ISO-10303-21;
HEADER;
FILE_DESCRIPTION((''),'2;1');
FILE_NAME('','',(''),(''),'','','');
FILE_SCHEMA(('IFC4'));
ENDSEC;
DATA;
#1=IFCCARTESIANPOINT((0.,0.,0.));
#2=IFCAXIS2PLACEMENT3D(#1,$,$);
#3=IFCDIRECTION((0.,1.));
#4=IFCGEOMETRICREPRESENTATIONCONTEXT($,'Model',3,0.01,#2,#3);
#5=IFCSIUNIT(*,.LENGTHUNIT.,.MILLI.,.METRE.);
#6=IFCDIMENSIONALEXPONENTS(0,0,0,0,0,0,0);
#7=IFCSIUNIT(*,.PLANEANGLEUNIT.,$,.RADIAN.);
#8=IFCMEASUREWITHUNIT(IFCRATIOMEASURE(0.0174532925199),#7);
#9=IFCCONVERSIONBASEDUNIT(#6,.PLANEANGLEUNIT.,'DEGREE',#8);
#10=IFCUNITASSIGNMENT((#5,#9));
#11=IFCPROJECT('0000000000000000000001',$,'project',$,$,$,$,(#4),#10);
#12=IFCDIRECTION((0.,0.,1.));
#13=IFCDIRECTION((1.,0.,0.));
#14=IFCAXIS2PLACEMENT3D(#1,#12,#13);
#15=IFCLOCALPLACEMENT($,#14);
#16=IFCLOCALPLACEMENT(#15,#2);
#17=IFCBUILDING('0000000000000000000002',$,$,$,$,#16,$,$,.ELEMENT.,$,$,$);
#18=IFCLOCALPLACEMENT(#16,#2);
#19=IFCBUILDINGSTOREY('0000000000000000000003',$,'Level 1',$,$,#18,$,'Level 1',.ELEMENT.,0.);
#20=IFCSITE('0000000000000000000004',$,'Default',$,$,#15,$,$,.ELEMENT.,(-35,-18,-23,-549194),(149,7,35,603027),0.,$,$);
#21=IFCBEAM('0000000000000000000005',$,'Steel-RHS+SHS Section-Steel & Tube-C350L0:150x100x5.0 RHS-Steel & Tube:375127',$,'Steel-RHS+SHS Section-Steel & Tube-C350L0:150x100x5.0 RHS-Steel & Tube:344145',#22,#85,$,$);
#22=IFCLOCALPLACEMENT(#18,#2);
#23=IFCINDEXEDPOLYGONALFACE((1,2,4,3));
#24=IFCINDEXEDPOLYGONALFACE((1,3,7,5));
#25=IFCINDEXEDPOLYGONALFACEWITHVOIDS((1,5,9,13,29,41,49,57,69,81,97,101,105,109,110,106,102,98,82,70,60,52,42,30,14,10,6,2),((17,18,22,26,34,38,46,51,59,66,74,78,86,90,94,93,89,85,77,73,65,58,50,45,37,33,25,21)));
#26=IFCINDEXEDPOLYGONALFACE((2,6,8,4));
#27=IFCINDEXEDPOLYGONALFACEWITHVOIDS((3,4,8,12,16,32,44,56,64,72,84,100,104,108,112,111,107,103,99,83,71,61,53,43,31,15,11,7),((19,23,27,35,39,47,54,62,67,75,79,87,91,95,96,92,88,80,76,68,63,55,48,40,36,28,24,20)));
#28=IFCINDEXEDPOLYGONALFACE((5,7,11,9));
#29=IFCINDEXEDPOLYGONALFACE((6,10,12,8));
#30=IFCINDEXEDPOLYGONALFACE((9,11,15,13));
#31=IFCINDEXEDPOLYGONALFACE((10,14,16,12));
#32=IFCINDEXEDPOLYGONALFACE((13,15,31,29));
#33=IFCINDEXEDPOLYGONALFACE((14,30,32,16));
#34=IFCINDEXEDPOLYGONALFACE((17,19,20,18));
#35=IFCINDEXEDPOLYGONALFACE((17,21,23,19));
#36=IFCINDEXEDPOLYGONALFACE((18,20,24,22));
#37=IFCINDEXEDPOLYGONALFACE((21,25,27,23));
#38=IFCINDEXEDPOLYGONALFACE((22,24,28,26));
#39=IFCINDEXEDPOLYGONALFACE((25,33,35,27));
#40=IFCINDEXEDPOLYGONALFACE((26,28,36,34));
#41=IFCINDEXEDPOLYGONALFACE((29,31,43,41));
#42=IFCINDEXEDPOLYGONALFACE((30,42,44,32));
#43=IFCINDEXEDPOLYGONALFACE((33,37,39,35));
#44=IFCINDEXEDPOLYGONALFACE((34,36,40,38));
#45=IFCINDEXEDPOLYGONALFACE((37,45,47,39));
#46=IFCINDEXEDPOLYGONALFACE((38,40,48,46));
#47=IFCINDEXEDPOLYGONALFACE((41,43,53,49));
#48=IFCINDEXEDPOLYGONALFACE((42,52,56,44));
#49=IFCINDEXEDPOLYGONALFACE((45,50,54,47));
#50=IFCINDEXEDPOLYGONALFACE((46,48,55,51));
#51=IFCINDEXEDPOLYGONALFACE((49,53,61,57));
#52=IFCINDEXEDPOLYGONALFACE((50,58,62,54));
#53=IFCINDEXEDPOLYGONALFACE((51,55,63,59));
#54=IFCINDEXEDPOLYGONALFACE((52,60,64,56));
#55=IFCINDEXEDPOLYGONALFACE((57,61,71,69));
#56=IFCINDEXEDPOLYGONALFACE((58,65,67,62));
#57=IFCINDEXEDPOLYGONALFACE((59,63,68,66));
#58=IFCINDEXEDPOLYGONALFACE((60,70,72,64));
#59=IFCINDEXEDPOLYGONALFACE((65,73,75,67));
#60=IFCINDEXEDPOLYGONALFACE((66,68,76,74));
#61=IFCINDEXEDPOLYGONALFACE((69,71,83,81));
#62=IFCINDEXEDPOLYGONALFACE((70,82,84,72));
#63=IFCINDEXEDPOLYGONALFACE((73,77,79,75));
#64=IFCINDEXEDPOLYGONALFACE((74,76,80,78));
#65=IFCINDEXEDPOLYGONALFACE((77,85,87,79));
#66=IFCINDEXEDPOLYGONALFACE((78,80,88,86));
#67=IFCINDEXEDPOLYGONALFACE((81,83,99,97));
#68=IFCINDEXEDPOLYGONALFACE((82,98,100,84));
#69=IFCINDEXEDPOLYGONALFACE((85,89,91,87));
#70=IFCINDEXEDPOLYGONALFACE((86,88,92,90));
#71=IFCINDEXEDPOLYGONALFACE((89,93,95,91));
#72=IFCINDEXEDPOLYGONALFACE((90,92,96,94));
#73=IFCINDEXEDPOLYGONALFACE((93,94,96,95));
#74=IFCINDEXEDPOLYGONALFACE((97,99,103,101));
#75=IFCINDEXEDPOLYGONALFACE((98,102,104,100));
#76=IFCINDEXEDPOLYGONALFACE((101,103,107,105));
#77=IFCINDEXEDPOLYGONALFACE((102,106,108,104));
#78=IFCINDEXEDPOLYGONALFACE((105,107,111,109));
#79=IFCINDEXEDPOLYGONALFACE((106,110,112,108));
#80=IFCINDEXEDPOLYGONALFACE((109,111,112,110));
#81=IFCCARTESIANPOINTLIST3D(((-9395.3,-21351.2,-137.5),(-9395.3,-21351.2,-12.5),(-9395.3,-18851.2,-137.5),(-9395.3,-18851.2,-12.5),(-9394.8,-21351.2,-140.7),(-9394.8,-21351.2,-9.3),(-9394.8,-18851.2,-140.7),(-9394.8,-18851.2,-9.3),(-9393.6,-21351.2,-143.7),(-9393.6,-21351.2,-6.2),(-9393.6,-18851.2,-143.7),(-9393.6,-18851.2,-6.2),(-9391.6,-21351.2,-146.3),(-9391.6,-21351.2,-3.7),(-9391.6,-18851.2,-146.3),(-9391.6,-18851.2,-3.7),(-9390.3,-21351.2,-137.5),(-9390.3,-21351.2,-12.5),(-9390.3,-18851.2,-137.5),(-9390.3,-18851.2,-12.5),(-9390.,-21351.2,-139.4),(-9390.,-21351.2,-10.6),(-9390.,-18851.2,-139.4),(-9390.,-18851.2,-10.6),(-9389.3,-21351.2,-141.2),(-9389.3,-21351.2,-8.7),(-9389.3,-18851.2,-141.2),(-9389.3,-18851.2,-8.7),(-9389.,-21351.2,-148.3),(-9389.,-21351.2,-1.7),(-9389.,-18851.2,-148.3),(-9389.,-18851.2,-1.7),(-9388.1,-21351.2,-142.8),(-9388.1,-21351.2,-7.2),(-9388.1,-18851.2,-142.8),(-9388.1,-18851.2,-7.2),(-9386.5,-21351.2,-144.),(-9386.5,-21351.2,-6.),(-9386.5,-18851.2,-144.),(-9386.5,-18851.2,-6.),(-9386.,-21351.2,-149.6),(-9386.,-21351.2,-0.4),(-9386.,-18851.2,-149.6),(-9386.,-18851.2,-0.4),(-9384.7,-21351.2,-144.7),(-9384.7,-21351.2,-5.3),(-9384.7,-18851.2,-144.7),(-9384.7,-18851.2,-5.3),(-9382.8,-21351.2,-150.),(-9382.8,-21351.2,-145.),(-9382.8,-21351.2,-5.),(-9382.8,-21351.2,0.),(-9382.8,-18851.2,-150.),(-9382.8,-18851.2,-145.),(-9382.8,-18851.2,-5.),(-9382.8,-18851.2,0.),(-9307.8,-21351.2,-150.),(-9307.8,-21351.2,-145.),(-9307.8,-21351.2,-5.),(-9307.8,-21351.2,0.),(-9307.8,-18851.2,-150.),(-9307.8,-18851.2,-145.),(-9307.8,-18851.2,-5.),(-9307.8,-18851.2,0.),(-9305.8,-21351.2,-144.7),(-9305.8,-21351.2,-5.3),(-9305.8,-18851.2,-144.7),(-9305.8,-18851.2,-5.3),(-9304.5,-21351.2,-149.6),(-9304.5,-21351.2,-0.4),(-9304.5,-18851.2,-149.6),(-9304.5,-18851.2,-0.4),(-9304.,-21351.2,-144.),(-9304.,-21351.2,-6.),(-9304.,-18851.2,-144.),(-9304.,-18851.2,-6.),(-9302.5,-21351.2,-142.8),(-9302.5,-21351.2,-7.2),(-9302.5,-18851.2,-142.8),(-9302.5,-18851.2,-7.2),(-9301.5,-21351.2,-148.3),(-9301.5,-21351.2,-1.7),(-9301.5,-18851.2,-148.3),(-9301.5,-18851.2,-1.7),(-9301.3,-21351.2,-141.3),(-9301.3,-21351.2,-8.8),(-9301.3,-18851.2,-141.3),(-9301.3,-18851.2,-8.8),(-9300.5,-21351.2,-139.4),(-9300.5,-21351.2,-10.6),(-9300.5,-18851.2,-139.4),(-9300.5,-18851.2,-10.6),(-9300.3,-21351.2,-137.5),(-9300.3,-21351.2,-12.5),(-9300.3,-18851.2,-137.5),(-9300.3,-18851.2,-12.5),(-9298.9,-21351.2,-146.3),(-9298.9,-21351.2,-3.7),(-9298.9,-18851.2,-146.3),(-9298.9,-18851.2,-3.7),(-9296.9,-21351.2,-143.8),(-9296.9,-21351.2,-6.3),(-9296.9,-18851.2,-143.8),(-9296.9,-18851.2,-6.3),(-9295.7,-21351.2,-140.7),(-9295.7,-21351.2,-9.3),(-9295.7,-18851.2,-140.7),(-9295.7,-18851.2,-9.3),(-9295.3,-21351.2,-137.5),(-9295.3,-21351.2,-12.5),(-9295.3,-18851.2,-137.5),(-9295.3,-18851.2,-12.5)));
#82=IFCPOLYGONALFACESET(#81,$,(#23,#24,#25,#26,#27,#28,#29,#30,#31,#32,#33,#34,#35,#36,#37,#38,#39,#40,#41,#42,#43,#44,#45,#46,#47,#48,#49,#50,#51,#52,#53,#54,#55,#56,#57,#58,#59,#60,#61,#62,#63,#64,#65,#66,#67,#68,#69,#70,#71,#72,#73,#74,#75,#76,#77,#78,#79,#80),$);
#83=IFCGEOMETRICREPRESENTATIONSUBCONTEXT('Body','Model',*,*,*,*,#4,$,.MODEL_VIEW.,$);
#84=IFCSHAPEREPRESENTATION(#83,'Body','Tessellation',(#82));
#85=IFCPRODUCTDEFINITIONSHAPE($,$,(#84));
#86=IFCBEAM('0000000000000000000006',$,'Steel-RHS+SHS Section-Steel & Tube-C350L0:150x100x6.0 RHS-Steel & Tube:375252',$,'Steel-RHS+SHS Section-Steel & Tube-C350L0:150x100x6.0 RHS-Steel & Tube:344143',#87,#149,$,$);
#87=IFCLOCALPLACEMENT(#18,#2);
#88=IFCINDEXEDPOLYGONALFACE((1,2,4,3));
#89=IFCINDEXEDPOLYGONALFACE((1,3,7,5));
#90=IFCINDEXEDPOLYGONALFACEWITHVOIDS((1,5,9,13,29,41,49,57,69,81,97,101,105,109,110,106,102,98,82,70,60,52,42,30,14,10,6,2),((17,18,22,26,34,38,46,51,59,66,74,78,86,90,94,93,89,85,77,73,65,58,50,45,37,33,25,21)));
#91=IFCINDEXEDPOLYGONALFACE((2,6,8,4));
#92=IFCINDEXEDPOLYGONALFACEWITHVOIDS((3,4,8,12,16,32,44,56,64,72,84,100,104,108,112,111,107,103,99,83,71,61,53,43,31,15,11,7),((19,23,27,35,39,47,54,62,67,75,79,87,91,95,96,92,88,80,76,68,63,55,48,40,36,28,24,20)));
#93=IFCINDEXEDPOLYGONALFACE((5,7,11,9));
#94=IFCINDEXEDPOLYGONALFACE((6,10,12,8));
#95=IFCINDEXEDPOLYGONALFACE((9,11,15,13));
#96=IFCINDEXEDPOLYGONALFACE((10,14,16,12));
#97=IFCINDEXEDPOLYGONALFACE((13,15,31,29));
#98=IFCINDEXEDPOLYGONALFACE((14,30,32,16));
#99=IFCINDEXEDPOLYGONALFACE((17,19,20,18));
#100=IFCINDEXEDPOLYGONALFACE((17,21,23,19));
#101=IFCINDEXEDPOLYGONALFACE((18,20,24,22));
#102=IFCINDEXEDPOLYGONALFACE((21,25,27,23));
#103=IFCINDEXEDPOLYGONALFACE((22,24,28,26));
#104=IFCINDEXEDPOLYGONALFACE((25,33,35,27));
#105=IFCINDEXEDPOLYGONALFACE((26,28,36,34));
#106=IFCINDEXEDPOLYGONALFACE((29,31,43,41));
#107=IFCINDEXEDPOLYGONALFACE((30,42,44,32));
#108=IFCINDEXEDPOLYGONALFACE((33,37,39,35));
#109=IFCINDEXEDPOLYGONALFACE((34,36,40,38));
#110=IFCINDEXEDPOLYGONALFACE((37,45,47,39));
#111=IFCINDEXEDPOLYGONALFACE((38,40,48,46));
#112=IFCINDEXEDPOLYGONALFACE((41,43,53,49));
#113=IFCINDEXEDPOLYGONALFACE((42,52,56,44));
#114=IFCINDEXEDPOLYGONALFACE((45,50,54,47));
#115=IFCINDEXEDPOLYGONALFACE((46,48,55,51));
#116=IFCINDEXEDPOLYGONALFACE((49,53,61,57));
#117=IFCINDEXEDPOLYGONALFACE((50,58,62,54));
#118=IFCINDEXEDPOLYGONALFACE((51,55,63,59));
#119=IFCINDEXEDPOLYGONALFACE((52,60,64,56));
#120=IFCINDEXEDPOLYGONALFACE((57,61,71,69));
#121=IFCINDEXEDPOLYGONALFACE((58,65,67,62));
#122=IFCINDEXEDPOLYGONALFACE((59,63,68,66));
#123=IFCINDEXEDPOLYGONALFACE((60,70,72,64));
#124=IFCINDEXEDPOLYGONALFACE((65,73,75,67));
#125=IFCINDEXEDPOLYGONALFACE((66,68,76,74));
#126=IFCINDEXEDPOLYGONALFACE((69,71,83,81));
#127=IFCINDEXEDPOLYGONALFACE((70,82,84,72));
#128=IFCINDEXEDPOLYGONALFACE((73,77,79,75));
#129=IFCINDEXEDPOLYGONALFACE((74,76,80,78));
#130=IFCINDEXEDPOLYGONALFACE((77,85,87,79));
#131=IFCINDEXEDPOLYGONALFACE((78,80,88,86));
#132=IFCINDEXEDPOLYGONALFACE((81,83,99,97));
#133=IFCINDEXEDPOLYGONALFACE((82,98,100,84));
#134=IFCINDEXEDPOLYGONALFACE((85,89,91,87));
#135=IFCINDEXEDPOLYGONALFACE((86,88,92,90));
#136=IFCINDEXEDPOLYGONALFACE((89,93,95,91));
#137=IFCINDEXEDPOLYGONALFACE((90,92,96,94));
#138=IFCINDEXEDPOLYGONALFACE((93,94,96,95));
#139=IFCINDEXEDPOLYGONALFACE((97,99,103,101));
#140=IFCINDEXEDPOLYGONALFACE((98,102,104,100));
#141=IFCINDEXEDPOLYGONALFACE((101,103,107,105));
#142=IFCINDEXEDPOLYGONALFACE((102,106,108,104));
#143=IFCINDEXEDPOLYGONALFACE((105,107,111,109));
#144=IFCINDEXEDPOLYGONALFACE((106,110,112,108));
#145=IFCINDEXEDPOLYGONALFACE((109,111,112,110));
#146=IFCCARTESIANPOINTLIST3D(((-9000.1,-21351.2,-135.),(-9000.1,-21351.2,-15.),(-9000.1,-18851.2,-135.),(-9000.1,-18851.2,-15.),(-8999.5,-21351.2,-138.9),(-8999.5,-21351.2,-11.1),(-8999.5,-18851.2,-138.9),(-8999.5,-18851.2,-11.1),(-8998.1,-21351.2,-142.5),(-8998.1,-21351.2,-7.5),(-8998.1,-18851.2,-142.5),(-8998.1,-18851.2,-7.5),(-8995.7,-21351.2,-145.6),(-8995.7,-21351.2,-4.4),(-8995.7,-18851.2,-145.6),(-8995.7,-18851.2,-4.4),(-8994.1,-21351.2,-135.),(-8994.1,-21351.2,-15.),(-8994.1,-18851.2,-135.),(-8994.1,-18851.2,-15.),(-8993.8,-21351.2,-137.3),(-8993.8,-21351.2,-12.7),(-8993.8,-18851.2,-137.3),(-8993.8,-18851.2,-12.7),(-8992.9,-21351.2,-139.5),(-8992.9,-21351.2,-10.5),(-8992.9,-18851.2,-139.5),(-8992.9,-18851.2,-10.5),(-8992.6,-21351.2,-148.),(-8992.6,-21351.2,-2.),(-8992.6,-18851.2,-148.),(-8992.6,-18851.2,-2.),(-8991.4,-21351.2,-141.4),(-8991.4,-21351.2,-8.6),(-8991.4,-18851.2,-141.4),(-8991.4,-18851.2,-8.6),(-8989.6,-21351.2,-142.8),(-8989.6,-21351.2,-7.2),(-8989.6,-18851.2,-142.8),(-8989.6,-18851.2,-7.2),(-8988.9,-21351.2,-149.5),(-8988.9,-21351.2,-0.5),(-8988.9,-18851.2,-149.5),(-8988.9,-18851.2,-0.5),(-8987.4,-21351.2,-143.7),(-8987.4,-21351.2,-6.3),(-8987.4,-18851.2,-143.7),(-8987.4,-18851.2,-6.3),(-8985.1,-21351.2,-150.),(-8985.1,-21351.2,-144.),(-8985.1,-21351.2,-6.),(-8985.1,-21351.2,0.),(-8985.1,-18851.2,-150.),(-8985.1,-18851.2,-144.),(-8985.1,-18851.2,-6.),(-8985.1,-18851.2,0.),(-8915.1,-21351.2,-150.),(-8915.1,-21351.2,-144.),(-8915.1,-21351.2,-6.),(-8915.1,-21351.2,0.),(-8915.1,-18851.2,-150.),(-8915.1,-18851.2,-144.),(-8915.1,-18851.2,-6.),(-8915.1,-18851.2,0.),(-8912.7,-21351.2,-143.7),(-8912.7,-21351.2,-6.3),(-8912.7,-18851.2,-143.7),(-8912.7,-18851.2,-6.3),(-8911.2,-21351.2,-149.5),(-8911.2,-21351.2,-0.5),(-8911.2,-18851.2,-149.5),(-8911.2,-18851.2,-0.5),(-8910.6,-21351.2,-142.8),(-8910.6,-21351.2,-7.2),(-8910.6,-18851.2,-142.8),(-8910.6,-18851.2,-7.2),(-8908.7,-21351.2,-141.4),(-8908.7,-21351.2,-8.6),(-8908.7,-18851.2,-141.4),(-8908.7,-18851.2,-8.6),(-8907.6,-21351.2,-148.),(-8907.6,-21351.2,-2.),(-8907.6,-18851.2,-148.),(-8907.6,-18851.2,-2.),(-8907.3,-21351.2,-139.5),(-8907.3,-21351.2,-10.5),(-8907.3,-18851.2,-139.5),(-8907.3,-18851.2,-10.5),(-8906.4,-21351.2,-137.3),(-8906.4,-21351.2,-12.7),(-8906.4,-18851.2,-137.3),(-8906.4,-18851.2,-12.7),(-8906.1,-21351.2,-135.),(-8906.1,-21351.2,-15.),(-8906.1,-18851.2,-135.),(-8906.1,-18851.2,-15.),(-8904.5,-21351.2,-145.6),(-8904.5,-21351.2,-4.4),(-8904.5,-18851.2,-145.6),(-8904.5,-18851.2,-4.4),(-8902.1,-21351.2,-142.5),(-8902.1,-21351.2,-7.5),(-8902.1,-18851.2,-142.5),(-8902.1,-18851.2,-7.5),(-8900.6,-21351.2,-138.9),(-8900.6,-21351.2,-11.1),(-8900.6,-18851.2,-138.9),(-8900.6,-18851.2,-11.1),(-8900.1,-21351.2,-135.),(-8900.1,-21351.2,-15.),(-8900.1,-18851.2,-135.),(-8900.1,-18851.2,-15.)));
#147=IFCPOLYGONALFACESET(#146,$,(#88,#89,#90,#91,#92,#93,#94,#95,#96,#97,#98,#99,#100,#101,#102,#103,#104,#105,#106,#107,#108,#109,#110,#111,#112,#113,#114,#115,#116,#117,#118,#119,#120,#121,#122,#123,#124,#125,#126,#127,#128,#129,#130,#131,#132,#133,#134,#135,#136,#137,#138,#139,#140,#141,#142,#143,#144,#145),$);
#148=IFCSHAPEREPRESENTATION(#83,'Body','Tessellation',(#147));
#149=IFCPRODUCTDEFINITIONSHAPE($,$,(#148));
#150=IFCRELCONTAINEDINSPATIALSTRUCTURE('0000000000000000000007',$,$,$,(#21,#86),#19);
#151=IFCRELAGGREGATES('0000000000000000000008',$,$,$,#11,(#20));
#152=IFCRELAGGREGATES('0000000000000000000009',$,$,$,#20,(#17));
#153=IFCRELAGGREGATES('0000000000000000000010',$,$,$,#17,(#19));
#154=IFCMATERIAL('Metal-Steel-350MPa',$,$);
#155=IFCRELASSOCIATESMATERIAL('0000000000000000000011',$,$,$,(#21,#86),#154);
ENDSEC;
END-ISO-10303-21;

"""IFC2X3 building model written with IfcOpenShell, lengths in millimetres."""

from ifc_helpers import new_model, entity, si_unit, converted_unit, direction, frame, frame_2d, origin, origin_with_axes, place, context, subcontext, project, spatial, polyline, circle_curve, parameter, trimmed, segment, composite_curve, outline, extrude, material, element, save


model = new_model("IFC2X3")

# Units and contexts
model_context = context("Model", 3, precision=0.01, world=origin(), true_north=direction((0.0, 1.0)))
body_context = subcontext(model_context, "Body", "Model", "MODEL_VIEW")
ifc_project = project(units=[si_unit("LENGTHUNIT", "METRE", prefix="MILLI"), converted_unit("PLANEANGLEUNIT", "DEGREE", entity("IfcRatioMeasure", 0.0174532925199), si_unit("PLANEANGLEUNIT", "RADIAN"), dimensions=[0, 0, 0, 0, 0, 0, 0])], contexts=[model_context])

# Site, building, storey
site_placement = place(None, origin_with_axes())
site = spatial("IfcSite", under=ifc_project, at=site_placement, Name="Default", CompositionType="ELEMENT", RefLatitude=(-35, -18, -23, -549194), RefLongitude=(149, 7, 35, 603027), RefElevation=0.0)
building_placement = place(site_placement, origin())
building = spatial("IfcBuilding", under=site, at=building_placement, CompositionType="ELEMENT")
storey_placement = place(building_placement, origin())
storey = spatial("IfcBuildingStorey", under=building, at=storey_placement, Name="Level 1", LongName="Level 1", CompositionType="ELEMENT", Elevation=0.0)

# Beams
ifc_material = material(Name="Metal-Steel-350MPa")
beam_1_placement = place(storey_placement, frame((-9345.3, -18851.2, 0.0), z_axis=(0.0, 0.0, 1.0), x_axis=(0.0, -1.0, 0.0)))
element("IfcBeam", 1, at=beam_1_placement, inside=storey, material=ifc_material, Name="Steel-RHS+SHS Section-Steel & Tube-C350L0:150x100x5.0 RHS-Steel & Tube:375127", ObjectType="Steel-RHS+SHS Section-Steel & Tube-C350L0:150x100x5.0 RHS-Steel & Tube:344145", context=body_context, shape_type="SweptSolid", body=[
    extrude(outline(composite_curve([segment(trimmed(circle_curve(frame_2d((-37.5, -62.5), x_axis=(1.0, 0.0)), 12.5), [parameter(180.0)], [parameter(270.0)], True, "PARAMETER"), True, "CONTINUOUS"), segment(polyline([(-37.5, -75.0), (37.5, -75.0)]), True, "CONTINUOUS"), segment(trimmed(circle_curve(frame_2d((37.5, -62.5), x_axis=(1.0, 0.0)), 12.5), [parameter(270.0)], [parameter(0.0)], True, "PARAMETER"), True, "CONTINUOUS"), segment(polyline([(50.0, -62.5), (50.0, 62.5)]), True, "CONTINUOUS"), segment(trimmed(circle_curve(frame_2d((37.5, 62.5), x_axis=(1.0, 0.0)), 12.5), [parameter(0.0)], [parameter(90.0)], True, "PARAMETER"), True, "CONTINUOUS"), segment(polyline([(37.5, 75.0), (-37.5, 75.0)]), True, "CONTINUOUS"), segment(trimmed(circle_curve(frame_2d((-37.5, 62.5), x_axis=(1.0, 0.0)), 12.5), [parameter(90.0)], [parameter(180.0)], True, "PARAMETER"), True, "CONTINUOUS"), segment(polyline([(-50.0, 62.5), (-50.0, -62.5)]), True, "CONTINUOUS")], self_intersect=False), holes=[composite_curve([segment(polyline([(37.5, -70.0), (-37.5, -70.0)]), True, "CONTINUOUS"), segment(trimmed(circle_curve(frame_2d((-37.5, -62.5), x_axis=(1.0, 0.0)), 7.5), [parameter(180.0)], [parameter(270.0)], True, "PARAMETER"), False, "CONTINUOUS"), segment(polyline([(-45.0, -62.5), (-45.0, 62.5)]), True, "CONTINUOUS"), segment(trimmed(circle_curve(frame_2d((-37.5, 62.5), x_axis=(1.0, 0.0)), 7.5), [parameter(90.0)], [parameter(180.0)], True, "PARAMETER"), False, "CONTINUOUS"), segment(polyline([(-37.5, 70.0), (37.5, 70.0)]), True, "CONTINUOUS"), segment(trimmed(circle_curve(frame_2d((37.5, 62.5), x_axis=(1.0, 0.0)), 7.5), [parameter(360.0)], [parameter(90.0)], True, "PARAMETER"), False, "CONTINUOUS"), segment(polyline([(45.0, 62.5), (45.0, -62.5)]), True, "CONTINUOUS"), segment(trimmed(circle_curve(frame_2d((37.5, -62.5), x_axis=(1.0, 0.0)), 7.5), [parameter(270.0)], [parameter(0.0)], True, "PARAMETER"), False, "CONTINUOUS")], self_intersect=False)]), frame((0.0, 0.0, -75.0), z_axis=(1.0, 0.0, 0.0), x_axis=(0.0, -1.0, 0.0)), (0.0, 0.0, 1.0), 2500.0),
])
beam_2_placement = place(storey_placement, frame((-8950.1, -18851.2, 0.0), z_axis=(0.0, 0.0, 1.0), x_axis=(0.0, -1.0, 0.0)))
element("IfcBeam", 2, at=beam_2_placement, inside=storey, material=ifc_material, Name="Steel-RHS+SHS Section-Steel & Tube-C350L0:150x100x6.0 RHS-Steel & Tube:375252", ObjectType="Steel-RHS+SHS Section-Steel & Tube-C350L0:150x100x6.0 RHS-Steel & Tube:344143", context=body_context, shape_type="SweptSolid", body=[
    extrude(outline(composite_curve([segment(trimmed(circle_curve(frame_2d((-35.0, -60.0), x_axis=(1.0, 0.0)), 15.0), [parameter(180.0)], [parameter(270.0)], True, "PARAMETER"), True, "CONTINUOUS"), segment(polyline([(-35.0, -75.0), (35.0, -75.0)]), True, "CONTINUOUS"), segment(trimmed(circle_curve(frame_2d((35.0, -60.0), x_axis=(1.0, 0.0)), 15.0), [parameter(270.0)], [parameter(0.0)], True, "PARAMETER"), True, "CONTINUOUS"), segment(polyline([(50.0, -60.0), (50.0, 60.0)]), True, "CONTINUOUS"), segment(trimmed(circle_curve(frame_2d((35.0, 60.0), x_axis=(1.0, 0.0)), 15.0), [parameter(0.0)], [parameter(90.0)], True, "PARAMETER"), True, "CONTINUOUS"), segment(polyline([(35.0, 75.0), (-35.0, 75.0)]), True, "CONTINUOUS"), segment(trimmed(circle_curve(frame_2d((-35.0, 60.0), x_axis=(1.0, 0.0)), 15.0), [parameter(90.0)], [parameter(180.0)], True, "PARAMETER"), True, "CONTINUOUS"), segment(polyline([(-50.0, 60.0), (-50.0, -60.0)]), True, "CONTINUOUS")], self_intersect=False), holes=[composite_curve([segment(polyline([(35.0, -69.0), (-35.0, -69.0)]), True, "CONTINUOUS"), segment(trimmed(circle_curve(frame_2d((-35.0, -60.0), x_axis=(1.0, 0.0)), 9.0), [parameter(180.0)], [parameter(270.0)], True, "PARAMETER"), False, "CONTINUOUS"), segment(polyline([(-44.0, -60.0), (-44.0, 60.0)]), True, "CONTINUOUS"), segment(trimmed(circle_curve(frame_2d((-35.0, 60.0), x_axis=(1.0, 0.0)), 9.0), [parameter(90.0)], [parameter(180.0)], True, "PARAMETER"), False, "CONTINUOUS"), segment(polyline([(-35.0, 69.0), (35.0, 69.0)]), True, "CONTINUOUS"), segment(trimmed(circle_curve(frame_2d((35.0, 60.0), x_axis=(1.0, 0.0)), 9.0), [parameter(360.0)], [parameter(90.0)], True, "PARAMETER"), False, "CONTINUOUS"), segment(polyline([(44.0, 60.0), (44.0, -60.0)]), True, "CONTINUOUS"), segment(trimmed(circle_curve(frame_2d((35.0, -60.0), x_axis=(1.0, 0.0)), 9.0), [parameter(270.0)], [parameter(360.0)], True, "PARAMETER"), False, "CONTINUOUS")], self_intersect=False)]), frame((0.0, 0.0, -75.0), z_axis=(1.0, 0.0, 0.0), x_axis=(0.0, -1.0, 0.0)), (0.0, 0.0, 1.0), 2500.0),
])

save(model, "model.ifc")
